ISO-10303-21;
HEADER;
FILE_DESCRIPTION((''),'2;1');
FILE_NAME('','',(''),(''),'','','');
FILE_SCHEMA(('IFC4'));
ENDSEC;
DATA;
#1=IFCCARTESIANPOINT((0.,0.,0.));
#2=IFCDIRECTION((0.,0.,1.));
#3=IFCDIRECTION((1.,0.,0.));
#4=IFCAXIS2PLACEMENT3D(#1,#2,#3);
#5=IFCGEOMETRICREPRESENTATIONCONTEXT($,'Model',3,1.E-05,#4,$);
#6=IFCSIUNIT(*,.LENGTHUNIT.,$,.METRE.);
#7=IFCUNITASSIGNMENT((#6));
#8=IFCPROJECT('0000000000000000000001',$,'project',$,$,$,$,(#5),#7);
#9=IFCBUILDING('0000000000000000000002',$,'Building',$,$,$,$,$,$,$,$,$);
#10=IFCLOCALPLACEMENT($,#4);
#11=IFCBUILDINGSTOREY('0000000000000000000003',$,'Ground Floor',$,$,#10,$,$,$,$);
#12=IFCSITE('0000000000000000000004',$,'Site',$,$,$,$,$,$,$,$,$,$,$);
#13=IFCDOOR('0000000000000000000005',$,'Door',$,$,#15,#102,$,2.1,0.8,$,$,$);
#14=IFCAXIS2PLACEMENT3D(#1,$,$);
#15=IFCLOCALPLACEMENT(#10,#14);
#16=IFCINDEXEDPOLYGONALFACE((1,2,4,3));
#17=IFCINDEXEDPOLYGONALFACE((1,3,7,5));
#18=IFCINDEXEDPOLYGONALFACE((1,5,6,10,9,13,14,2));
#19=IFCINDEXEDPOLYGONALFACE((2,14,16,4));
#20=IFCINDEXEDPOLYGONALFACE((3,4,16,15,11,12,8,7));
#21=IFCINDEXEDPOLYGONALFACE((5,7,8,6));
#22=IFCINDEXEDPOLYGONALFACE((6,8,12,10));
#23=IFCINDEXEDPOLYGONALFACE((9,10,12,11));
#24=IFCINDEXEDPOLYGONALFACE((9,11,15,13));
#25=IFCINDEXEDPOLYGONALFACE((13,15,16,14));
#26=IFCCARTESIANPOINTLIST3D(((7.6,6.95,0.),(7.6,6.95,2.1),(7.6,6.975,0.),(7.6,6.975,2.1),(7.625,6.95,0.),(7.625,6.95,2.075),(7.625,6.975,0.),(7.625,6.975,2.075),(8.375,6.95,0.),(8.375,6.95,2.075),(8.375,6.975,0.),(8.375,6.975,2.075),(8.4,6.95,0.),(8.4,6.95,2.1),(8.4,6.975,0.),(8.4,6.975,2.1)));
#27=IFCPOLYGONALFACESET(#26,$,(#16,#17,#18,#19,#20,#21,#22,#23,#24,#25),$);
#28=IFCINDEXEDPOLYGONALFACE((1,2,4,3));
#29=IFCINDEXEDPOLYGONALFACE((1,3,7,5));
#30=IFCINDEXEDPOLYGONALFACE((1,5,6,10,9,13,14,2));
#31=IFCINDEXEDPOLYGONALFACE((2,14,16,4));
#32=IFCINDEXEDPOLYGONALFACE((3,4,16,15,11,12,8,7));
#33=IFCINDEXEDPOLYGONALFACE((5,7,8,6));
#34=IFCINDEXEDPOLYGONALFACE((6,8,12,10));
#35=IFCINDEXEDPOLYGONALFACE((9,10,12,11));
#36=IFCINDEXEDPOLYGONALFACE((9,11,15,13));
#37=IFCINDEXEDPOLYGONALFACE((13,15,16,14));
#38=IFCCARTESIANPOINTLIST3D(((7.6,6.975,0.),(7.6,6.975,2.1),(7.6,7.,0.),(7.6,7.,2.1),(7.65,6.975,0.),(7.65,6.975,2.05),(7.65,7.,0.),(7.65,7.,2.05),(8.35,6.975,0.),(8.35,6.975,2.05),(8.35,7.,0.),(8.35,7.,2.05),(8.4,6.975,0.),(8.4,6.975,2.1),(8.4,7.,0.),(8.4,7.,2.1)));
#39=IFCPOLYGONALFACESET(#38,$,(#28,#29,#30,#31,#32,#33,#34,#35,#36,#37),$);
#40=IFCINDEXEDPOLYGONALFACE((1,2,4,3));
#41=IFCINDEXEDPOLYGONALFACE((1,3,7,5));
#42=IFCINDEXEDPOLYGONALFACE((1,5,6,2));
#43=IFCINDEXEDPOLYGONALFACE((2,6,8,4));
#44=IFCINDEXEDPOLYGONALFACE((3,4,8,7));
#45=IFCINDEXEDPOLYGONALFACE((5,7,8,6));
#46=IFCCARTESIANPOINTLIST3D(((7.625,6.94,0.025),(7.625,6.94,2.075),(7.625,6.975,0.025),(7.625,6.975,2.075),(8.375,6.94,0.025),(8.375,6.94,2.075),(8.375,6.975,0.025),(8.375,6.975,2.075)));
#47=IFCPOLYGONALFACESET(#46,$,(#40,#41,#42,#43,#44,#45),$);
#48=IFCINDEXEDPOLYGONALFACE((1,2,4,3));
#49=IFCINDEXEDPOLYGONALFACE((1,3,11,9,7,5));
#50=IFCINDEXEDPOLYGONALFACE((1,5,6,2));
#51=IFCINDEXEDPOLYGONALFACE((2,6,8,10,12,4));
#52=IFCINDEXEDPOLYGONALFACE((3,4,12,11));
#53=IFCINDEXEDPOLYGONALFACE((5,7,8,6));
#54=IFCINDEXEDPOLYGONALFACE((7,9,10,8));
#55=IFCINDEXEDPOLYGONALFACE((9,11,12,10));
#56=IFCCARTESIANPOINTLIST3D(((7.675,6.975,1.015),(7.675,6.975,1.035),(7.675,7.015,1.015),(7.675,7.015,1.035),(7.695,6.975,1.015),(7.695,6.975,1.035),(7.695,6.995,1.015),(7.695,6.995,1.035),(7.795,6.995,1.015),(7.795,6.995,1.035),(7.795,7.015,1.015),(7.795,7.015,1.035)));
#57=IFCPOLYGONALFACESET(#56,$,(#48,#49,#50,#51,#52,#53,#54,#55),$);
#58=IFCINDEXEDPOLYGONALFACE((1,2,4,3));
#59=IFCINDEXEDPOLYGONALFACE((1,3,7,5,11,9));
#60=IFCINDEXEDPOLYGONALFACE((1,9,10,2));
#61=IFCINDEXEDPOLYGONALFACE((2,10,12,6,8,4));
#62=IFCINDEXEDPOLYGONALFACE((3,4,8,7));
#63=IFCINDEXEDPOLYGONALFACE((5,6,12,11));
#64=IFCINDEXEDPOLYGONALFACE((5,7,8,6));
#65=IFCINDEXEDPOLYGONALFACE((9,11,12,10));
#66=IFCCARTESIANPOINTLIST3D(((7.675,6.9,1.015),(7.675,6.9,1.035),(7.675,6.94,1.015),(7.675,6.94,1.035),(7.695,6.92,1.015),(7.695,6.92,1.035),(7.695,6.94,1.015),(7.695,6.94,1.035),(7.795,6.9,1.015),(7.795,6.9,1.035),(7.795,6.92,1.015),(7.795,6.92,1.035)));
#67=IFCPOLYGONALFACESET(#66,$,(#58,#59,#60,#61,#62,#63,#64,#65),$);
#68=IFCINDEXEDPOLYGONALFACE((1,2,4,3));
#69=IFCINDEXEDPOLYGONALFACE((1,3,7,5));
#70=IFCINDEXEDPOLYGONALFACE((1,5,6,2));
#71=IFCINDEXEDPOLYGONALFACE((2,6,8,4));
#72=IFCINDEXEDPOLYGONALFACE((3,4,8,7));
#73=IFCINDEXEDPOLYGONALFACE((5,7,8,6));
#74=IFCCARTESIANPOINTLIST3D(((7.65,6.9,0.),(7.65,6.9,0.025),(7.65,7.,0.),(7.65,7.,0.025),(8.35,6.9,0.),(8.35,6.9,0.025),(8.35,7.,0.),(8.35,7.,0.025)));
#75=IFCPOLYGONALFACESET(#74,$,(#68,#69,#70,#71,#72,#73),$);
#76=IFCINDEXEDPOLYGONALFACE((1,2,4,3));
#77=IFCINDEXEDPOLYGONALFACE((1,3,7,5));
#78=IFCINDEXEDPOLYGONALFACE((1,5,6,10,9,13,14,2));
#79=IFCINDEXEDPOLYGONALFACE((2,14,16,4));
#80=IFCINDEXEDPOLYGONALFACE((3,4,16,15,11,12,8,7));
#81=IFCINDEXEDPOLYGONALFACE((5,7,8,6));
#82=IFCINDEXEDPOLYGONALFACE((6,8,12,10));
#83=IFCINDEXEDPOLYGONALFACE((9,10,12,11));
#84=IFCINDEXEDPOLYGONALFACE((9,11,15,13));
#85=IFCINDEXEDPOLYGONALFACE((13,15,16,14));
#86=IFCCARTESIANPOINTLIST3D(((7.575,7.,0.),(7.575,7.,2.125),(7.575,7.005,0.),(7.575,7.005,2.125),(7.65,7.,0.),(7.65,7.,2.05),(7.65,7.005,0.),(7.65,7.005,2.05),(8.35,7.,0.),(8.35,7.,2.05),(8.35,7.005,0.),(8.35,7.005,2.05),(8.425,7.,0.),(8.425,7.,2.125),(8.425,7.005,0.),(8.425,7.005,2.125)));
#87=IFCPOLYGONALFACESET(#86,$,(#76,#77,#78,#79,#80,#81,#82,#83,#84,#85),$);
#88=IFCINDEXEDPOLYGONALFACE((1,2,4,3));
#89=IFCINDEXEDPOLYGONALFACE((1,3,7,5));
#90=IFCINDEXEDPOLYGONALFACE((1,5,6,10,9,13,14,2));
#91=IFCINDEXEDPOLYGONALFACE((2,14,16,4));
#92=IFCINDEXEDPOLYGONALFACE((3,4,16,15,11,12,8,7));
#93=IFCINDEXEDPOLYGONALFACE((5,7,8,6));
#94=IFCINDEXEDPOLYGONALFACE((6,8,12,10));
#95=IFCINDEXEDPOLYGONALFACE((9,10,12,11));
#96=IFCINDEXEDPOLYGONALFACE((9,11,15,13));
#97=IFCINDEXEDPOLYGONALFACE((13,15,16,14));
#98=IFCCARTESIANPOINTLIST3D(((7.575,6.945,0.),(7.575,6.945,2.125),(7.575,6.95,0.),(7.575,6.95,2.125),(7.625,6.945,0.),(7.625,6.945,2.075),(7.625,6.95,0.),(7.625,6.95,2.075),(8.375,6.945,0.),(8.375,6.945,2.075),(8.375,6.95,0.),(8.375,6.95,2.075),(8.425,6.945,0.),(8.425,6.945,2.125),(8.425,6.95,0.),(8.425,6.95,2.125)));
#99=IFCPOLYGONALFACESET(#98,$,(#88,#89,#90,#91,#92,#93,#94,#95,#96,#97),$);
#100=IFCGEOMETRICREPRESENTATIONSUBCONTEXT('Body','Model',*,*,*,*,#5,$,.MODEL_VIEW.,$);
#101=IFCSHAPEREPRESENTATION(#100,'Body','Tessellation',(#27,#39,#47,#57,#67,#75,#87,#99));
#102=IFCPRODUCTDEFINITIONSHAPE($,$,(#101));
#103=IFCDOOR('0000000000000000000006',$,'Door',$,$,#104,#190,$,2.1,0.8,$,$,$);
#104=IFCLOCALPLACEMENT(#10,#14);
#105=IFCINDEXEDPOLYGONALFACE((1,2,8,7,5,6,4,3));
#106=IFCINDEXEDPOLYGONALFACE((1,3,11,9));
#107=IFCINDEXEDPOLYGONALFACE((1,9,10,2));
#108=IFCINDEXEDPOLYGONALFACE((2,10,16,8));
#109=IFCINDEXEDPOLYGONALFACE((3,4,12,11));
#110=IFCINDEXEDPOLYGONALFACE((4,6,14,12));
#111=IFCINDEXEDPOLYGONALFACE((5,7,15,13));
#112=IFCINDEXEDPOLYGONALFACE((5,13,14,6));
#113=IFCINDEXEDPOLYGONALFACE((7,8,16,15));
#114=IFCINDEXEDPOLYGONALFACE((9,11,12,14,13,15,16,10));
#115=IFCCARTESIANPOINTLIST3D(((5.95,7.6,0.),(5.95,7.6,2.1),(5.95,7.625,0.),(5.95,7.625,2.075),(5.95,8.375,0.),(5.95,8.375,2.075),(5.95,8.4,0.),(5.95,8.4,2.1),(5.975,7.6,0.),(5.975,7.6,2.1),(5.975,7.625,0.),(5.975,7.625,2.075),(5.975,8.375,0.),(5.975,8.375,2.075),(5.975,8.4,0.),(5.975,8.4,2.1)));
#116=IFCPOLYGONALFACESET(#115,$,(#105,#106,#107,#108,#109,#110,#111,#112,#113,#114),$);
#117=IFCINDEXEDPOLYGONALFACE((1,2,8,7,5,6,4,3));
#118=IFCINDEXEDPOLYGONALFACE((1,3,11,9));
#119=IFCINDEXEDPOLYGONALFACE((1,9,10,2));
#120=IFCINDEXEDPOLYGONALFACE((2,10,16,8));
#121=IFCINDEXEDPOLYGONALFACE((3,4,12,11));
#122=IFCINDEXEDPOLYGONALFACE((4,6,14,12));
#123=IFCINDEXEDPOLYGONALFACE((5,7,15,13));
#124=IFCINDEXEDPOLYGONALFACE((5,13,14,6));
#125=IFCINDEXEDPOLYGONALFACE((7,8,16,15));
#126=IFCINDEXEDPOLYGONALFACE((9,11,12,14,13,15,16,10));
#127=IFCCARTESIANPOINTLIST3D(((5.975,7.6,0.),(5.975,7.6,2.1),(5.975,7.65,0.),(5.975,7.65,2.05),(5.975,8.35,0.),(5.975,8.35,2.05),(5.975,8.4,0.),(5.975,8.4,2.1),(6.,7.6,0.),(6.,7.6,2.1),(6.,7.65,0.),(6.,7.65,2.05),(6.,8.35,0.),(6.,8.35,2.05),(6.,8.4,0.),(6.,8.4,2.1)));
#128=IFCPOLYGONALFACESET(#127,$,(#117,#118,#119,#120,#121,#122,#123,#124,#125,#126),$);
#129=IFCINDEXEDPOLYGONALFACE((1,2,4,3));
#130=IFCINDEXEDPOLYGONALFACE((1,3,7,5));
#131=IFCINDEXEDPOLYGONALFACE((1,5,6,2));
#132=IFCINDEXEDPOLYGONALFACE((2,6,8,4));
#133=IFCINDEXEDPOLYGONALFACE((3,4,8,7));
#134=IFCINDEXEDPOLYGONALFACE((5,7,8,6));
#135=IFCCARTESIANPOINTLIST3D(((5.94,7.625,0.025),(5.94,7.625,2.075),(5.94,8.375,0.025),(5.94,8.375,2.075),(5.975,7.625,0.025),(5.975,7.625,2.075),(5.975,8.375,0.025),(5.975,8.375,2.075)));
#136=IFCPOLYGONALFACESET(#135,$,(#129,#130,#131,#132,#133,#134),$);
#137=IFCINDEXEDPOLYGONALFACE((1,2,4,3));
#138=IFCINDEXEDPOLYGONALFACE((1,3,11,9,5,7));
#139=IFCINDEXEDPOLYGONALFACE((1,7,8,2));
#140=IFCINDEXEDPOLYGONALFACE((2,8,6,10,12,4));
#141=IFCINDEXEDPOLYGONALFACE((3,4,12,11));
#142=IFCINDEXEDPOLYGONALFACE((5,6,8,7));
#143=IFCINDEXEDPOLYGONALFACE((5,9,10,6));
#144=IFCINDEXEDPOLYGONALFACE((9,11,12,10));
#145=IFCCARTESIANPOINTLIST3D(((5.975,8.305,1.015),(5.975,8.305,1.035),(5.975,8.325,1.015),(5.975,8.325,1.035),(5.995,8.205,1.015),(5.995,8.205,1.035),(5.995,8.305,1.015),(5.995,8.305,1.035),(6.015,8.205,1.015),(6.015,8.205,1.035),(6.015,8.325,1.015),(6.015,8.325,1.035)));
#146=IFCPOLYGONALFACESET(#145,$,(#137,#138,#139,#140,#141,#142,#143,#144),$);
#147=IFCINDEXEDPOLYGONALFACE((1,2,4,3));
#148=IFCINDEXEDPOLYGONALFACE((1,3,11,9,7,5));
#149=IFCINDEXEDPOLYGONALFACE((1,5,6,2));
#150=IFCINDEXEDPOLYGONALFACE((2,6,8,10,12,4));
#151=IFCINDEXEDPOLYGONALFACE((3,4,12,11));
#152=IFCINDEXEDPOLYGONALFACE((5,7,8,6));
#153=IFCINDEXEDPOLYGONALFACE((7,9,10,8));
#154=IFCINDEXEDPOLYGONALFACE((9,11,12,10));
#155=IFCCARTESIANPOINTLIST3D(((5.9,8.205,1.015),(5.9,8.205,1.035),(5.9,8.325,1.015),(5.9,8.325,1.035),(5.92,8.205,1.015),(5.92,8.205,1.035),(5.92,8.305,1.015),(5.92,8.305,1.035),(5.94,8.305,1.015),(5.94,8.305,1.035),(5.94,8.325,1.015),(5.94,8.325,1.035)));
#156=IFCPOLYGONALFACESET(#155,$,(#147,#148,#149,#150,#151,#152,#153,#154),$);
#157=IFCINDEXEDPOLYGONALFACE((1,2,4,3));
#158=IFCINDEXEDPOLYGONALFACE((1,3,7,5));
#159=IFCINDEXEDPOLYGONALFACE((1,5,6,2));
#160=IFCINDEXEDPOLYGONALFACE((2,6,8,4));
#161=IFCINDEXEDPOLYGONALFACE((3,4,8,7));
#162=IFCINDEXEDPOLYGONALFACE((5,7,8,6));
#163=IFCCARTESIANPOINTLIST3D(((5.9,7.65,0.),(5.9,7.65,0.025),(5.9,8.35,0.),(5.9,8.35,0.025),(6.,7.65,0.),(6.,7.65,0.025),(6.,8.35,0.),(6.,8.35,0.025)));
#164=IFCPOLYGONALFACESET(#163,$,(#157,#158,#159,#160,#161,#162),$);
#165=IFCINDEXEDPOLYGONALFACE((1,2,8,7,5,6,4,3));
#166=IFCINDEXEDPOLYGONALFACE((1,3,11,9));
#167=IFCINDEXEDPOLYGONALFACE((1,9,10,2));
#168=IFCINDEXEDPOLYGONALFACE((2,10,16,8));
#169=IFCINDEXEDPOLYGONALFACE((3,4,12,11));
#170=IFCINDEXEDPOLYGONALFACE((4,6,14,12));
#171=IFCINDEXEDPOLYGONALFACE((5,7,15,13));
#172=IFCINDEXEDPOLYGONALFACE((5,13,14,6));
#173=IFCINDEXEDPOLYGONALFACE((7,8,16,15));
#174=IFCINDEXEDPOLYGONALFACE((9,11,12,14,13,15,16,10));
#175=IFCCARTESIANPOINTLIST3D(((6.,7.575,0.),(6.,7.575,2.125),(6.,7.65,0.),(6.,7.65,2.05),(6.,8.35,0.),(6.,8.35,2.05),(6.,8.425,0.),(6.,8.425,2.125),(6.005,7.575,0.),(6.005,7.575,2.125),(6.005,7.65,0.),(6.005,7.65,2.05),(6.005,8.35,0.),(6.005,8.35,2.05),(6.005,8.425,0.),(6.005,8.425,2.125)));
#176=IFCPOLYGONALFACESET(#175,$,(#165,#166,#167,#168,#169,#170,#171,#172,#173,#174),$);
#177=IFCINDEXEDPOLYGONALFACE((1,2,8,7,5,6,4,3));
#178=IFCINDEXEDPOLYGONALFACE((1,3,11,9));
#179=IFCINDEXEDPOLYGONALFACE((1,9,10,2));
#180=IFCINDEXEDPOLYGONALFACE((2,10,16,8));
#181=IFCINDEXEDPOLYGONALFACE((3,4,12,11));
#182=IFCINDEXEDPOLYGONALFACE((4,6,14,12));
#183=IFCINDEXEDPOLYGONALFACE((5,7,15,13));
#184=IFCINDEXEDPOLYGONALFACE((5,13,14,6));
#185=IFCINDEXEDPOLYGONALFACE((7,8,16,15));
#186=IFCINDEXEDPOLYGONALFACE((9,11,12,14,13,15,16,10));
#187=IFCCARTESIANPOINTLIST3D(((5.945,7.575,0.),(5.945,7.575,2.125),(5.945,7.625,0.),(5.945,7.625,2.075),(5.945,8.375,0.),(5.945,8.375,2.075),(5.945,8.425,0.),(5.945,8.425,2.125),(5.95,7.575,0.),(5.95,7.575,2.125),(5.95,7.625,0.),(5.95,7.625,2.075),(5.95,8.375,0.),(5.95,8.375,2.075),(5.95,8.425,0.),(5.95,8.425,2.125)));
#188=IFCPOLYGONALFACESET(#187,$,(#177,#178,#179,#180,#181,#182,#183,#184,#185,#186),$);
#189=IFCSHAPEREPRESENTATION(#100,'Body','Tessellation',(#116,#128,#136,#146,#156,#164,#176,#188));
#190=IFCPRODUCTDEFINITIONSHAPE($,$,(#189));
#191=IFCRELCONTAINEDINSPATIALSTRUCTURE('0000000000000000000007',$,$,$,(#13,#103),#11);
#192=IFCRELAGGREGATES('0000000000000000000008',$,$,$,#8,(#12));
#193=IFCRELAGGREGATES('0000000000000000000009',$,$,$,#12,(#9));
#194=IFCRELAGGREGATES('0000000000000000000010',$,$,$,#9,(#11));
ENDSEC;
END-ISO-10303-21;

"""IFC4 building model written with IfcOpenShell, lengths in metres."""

from ifc_helpers import new_model, si_unit, frame, origin_with_axes, place, context, subcontext, project, spatial, line, indexed_curve, outline, extrude, element, save


model = new_model("IFC4")

# Units and contexts
model_context = context("Model", 3, precision=1e-05, world=origin_with_axes())
body_context = subcontext(model_context, "Body", "Model", "MODEL_VIEW")
ifc_project = project(units=[si_unit("LENGTHUNIT", "METRE")], contexts=[model_context])

# Site, building, storey
site = spatial("IfcSite", under=ifc_project, Name="Site")
building = spatial("IfcBuilding", under=site, Name="Building")
storey_placement = place(None, origin_with_axes())
storey = spatial("IfcBuildingStorey", under=building, at=storey_placement, Name="Ground Floor")

# Doors
door_1_placement = place(storey_placement, frame((8.4, 7.0, 0.0), z_axis=(0.0, 0.0, 1.0), x_axis=(-1.0, 0.0, 0.0)))
element("IfcDoor", 1, at=door_1_placement, inside=storey, Name="Door", OverallHeight=2.1, OverallWidth=0.8, context=body_context, shape_type="SweptSolid", body=[
    extrude(outline(indexed_curve([(0.0, 0.0), (0.0, 2.1), (0.8, 2.1), (0.8, 0.0), (0.775, 0.0), (0.775, 2.075), (0.025, 2.075), (0.025, 0.0)], segments=[line(1, 2, 3, 4, 5, 6, 7, 8, 1)])), frame((0.0, 0.025, 0.0), z_axis=(0.0, -1.0, 0.0), x_axis=(1.0, 0.0, 0.0)), (0.0, 0.0, -1.0), 0.025),
    extrude(outline(indexed_curve([(0.0, 0.0), (0.0, 2.1), (0.8, 2.1), (0.8, 0.0), (0.75, 0.0), (0.75, 2.05), (0.05, 2.05), (0.05, 0.0)], segments=[line(1, 2, 3, 4, 5, 6, 7, 8, 1)])), frame((0.0, 0.0, 0.0), z_axis=(0.0, -1.0, 0.0), x_axis=(1.0, 0.0, 0.0)), (0.0, 0.0, -1.0), 0.025),
    extrude(outline(indexed_curve([(0.0, 0.0), (0.75, 0.0), (0.75, 0.035), (0.0, 0.035)], segments=[line(1, 2, 3, 4, 1)])), frame((0.025, 0.025, 0.025), z_axis=(0.0, 0.0, 1.0), x_axis=(1.0, 0.0, 0.0)), (0.0, 0.0, 1.0), 2.05),
    extrude(outline(indexed_curve([(0.0, 0.0), (0.0, -0.04), (-0.12, -0.04), (-0.12, -0.02), (-0.02, -0.02), (-0.02, 0.0)], segments=[line(1, 2, 3, 4, 5, 6, 1)])), frame((0.725, 0.025, 1.015), z_axis=(0.0, 0.0, 1.0), x_axis=(1.0, 0.0, 0.0)), (0.0, 0.0, 1.0), 0.02),
    extrude(outline(indexed_curve([(0.0, 0.0), (0.0, 0.04), (-0.12, 0.04), (-0.12, 0.02), (-0.02, 0.02), (-0.02, 0.0)], segments=[line(1, 2, 3, 4, 5, 6, 1)])), frame((0.725, 0.06, 1.015), z_axis=(0.0, 0.0, 1.0), x_axis=(1.0, 0.0, 0.0)), (0.0, 0.0, 1.0), 0.02),
    extrude(outline(indexed_curve([(0.0, 0.0), (0.7, 0.0), (0.7, 0.1), (0.0, 0.1)], segments=[line(1, 2, 3, 4, 1)])), frame((0.05, 0.0, 0.0), z_axis=(0.0, 0.0, 1.0), x_axis=(1.0, 0.0, 0.0)), (0.0, 0.0, 1.0), 0.025),
    extrude(outline(indexed_curve([(0.0, 0.0), (0.0, 2.125), (0.85, 2.125), (0.85, 0.0), (0.775, 0.0), (0.775, 2.05), (0.075, 2.05), (0.075, 0.0)], segments=[line(1, 2, 3, 4, 5, 6, 7, 8, 1)])), frame((-0.025, -0.005, 0.0), z_axis=(0.0, -1.0, 0.0), x_axis=(1.0, 0.0, 0.0)), (0.0, 0.0, -1.0), 0.005),
    extrude(outline(indexed_curve([(0.0, 0.0), (0.0, 2.125), (0.85, 2.125), (0.85, 0.0), (0.8, 0.0), (0.8, 2.075), (0.05, 2.075), (0.05, 0.0)], segments=[line(1, 2, 3, 4, 5, 6, 7, 8, 1)])), frame((-0.025, 0.05, 0.0), z_axis=(0.0, -1.0, 0.0), x_axis=(1.0, 0.0, 0.0)), (0.0, 0.0, -1.0), 0.005),
])
door_2_placement = place(storey_placement, frame((6.0, 7.6, 0.0), z_axis=(0.0, 0.0, 1.0), x_axis=(0.0, 1.0, 0.0)))
element("IfcDoor", 2, at=door_2_placement, inside=storey, Name="Door", OverallHeight=2.1, OverallWidth=0.8, context=body_context, shape_type="SweptSolid", body=[
    extrude(outline(indexed_curve([(0.0, 0.0), (0.0, 2.1), (0.8, 2.1), (0.8, 0.0), (0.775, 0.0), (0.775, 2.075), (0.025, 2.075), (0.025, 0.0)], segments=[line(1, 2, 3, 4, 5, 6, 7, 8, 1)])), frame((0.0, 0.025, 0.0), z_axis=(0.0, -1.0, 0.0), x_axis=(1.0, 0.0, 0.0)), (0.0, 0.0, -1.0), 0.025),
    extrude(outline(indexed_curve([(0.0, 0.0), (0.0, 2.1), (0.8, 2.1), (0.8, 0.0), (0.75, 0.0), (0.75, 2.05), (0.05, 2.05), (0.05, 0.0)], segments=[line(1, 2, 3, 4, 5, 6, 7, 8, 1)])), frame((0.0, 0.0, 0.0), z_axis=(0.0, -1.0, 0.0), x_axis=(1.0, 0.0, 0.0)), (0.0, 0.0, -1.0), 0.025),
    extrude(outline(indexed_curve([(0.0, 0.0), (0.75, 0.0), (0.75, 0.035), (0.0, 0.035)], segments=[line(1, 2, 3, 4, 1)])), frame((0.025, 0.025, 0.025), z_axis=(0.0, 0.0, 1.0), x_axis=(1.0, 0.0, 0.0)), (0.0, 0.0, 1.0), 2.05),
    extrude(outline(indexed_curve([(0.0, 0.0), (0.0, -0.04), (-0.12, -0.04), (-0.12, -0.02), (-0.02, -0.02), (-0.02, 0.0)], segments=[line(1, 2, 3, 4, 5, 6, 1)])), frame((0.725, 0.025, 1.015), z_axis=(0.0, 0.0, 1.0), x_axis=(1.0, 0.0, 0.0)), (0.0, 0.0, 1.0), 0.02),
    extrude(outline(indexed_curve([(0.0, 0.0), (0.0, 0.04), (-0.12, 0.04), (-0.12, 0.02), (-0.02, 0.02), (-0.02, 0.0)], segments=[line(1, 2, 3, 4, 5, 6, 1)])), frame((0.725, 0.06, 1.015), z_axis=(0.0, 0.0, 1.0), x_axis=(1.0, 0.0, 0.0)), (0.0, 0.0, 1.0), 0.02),
    extrude(outline(indexed_curve([(0.0, 0.0), (0.7, 0.0), (0.7, 0.1), (0.0, 0.1)], segments=[line(1, 2, 3, 4, 1)])), frame((0.05, 0.0, 0.0), z_axis=(0.0, 0.0, 1.0), x_axis=(1.0, 0.0, 0.0)), (0.0, 0.0, 1.0), 0.025),
    extrude(outline(indexed_curve([(0.0, 0.0), (0.0, 2.125), (0.85, 2.125), (0.85, 0.0), (0.775, 0.0), (0.775, 2.05), (0.075, 2.05), (0.075, 0.0)], segments=[line(1, 2, 3, 4, 5, 6, 7, 8, 1)])), frame((-0.025, -0.005, 0.0), z_axis=(0.0, -1.0, 0.0), x_axis=(1.0, 0.0, 0.0)), (0.0, 0.0, -1.0), 0.005),
    extrude(outline(indexed_curve([(0.0, 0.0), (0.0, 2.125), (0.85, 2.125), (0.85, 0.0), (0.8, 0.0), (0.8, 2.075), (0.05, 2.075), (0.05, 0.0)], segments=[line(1, 2, 3, 4, 5, 6, 7, 8, 1)])), frame((-0.025, 0.05, 0.0), z_axis=(0.0, -1.0, 0.0), x_axis=(1.0, 0.0, 0.0)), (0.0, 0.0, -1.0), 0.005),
])

save(model, "model.ifc")
